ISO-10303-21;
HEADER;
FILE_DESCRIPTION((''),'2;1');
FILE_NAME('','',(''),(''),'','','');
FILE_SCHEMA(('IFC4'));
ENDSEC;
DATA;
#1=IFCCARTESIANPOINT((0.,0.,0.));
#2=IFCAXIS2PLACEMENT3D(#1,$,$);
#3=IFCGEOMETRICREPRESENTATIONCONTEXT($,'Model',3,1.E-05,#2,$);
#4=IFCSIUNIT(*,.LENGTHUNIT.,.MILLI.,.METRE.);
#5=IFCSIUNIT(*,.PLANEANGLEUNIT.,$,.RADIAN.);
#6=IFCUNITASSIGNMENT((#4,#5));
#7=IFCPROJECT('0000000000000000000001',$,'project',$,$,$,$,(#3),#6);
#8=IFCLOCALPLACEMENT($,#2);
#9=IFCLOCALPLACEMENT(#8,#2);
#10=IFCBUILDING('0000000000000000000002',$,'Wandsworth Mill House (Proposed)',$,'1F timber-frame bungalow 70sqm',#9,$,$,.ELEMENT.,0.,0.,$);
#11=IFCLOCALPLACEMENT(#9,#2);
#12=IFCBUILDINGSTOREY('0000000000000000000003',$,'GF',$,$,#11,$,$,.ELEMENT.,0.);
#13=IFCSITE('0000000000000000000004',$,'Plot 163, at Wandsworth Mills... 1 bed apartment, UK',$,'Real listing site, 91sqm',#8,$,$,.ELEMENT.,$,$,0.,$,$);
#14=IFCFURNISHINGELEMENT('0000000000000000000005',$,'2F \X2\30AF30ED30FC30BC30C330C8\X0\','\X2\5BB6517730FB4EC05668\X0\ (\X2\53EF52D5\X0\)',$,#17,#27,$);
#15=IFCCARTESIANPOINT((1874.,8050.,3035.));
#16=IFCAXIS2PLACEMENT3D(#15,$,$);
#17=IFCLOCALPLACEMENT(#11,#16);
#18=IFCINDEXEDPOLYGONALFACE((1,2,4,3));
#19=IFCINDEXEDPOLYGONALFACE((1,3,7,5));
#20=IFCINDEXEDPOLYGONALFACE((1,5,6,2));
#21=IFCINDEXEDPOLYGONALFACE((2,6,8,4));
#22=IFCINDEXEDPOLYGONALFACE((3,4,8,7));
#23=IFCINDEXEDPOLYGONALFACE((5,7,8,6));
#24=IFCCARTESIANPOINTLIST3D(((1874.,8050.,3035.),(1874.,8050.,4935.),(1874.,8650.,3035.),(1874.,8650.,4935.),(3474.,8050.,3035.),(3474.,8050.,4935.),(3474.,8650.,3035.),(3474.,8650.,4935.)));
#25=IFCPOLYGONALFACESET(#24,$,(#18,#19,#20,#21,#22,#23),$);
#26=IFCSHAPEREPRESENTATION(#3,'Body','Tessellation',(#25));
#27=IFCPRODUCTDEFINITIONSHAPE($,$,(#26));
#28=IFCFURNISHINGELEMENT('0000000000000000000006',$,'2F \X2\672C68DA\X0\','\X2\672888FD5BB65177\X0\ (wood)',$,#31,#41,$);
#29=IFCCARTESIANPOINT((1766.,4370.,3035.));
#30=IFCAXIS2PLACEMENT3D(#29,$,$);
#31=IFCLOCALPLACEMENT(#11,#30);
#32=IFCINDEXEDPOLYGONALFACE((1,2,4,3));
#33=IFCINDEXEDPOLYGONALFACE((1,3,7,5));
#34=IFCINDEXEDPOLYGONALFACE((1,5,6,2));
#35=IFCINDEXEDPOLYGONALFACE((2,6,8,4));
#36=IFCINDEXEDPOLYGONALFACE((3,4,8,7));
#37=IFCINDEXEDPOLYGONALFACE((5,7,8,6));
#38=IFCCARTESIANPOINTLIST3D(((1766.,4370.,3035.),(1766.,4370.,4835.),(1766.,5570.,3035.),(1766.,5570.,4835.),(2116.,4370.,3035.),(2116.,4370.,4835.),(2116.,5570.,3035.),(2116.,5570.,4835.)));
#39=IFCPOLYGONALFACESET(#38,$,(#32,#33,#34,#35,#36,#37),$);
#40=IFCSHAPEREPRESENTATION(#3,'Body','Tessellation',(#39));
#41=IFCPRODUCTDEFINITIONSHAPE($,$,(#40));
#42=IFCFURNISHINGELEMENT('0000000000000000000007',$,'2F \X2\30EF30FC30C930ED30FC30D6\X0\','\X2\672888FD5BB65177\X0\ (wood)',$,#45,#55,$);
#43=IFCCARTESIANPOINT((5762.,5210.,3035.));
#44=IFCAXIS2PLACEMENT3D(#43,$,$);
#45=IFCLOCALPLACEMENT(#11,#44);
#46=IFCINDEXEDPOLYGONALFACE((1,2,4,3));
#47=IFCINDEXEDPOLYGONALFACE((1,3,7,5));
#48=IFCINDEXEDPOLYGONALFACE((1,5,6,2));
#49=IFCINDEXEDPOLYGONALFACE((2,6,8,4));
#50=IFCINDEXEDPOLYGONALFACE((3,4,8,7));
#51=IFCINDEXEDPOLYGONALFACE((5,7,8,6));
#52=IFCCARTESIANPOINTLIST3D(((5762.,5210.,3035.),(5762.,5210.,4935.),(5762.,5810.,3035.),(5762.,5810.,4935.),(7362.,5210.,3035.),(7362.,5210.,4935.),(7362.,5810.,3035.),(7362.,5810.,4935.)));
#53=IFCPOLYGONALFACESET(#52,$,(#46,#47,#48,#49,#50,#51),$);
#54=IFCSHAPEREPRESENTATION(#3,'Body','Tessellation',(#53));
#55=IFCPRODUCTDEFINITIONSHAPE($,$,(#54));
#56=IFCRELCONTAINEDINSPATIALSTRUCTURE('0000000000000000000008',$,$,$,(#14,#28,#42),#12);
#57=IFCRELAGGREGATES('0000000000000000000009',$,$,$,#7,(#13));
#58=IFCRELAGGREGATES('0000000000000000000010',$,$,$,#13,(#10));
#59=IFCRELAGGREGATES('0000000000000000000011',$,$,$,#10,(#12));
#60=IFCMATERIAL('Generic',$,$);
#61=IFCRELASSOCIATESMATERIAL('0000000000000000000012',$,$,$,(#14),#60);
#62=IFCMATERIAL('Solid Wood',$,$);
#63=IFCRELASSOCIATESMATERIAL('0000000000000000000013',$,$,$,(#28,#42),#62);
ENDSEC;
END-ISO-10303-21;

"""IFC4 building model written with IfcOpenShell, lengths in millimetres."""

from ifc_helpers import new_model, si_unit, frame, frame_2d, origin, place, context, project, spatial, rectangle, extrude, material, element, save


model = new_model("IFC4")

# Units and contexts
model_context = context("Model", 3, precision=1e-05, world=origin())
ifc_project = project(units=[si_unit("LENGTHUNIT", "METRE", prefix="MILLI"), si_unit("PLANEANGLEUNIT", "RADIAN")], contexts=[model_context])

# Site, building, storey
site_placement = place(None, origin())
site = spatial("IfcSite", under=ifc_project, at=site_placement, Name="Plot 163, at Wandsworth Mills... 1 bed apartment, UK", ObjectType="Real listing site, 91sqm", CompositionType="ELEMENT", RefElevation=0.0)
building_placement = place(site_placement, origin())
building = spatial("IfcBuilding", under=site, at=building_placement, Name="Wandsworth Mill House (Proposed)", ObjectType="1F timber-frame bungalow 70sqm", CompositionType="ELEMENT", ElevationOfRefHeight=0.0, ElevationOfTerrain=0.0)
storey_placement = place(building_placement, origin())
storey = spatial("IfcBuildingStorey", under=building, at=storey_placement, Name="GF", CompositionType="ELEMENT", Elevation=0.0)

# Shared definitions
ifc_material_1 = material(Name="Solid Wood")

# Shared definitions
ifc_material_2 = material(Name="Generic")

# Furnishing elements
furnishing_1_placement = place(storey_placement, frame((1874.0, 8050.0, 3035.0)))
element("IfcFurnishingElement", 1, at=furnishing_1_placement, inside=storey, material=ifc_material_2, Name="2F クローゼット", Description="家具・什器 (可動)", context=model_context, shape_type="SweptSolid", body=[
    extrude(rectangle(XDim=1600.0, YDim=600.0, at=frame_2d((800.0, 300.0))), frame((1874.0, 8050.0, 3035.0)), (0.0, 0.0, 1.0), 1900.0),
])
furnishing_2_placement = place(storey_placement, frame((1766.0, 4370.0, 3035.0)))
element("IfcFurnishingElement", 2, at=furnishing_2_placement, inside=storey, material=ifc_material_1, Name="2F 本棚", Description="木製家具 (wood)", context=model_context, shape_type="SweptSolid", body=[
    extrude(rectangle(XDim=350.0, YDim=1200.0, at=frame_2d((175.0, 600.0))), frame((1766.0, 4370.0, 3035.0)), (0.0, 0.0, 1.0), 1800.0),
])
furnishing_3_placement = place(storey_placement, frame((5762.0, 5210.0, 3035.0)))
element("IfcFurnishingElement", 3, at=furnishing_3_placement, inside=storey, material=ifc_material_1, Name="2F ワードローブ", Description="木製家具 (wood)", context=model_context, shape_type="SweptSolid", body=[
    extrude(rectangle(XDim=1600.0, YDim=600.0, at=frame_2d((800.0, 300.0))), frame((5762.0, 5210.0, 3035.0)), (0.0, 0.0, 1.0), 1900.0),
])

save(model, "model.ifc")
